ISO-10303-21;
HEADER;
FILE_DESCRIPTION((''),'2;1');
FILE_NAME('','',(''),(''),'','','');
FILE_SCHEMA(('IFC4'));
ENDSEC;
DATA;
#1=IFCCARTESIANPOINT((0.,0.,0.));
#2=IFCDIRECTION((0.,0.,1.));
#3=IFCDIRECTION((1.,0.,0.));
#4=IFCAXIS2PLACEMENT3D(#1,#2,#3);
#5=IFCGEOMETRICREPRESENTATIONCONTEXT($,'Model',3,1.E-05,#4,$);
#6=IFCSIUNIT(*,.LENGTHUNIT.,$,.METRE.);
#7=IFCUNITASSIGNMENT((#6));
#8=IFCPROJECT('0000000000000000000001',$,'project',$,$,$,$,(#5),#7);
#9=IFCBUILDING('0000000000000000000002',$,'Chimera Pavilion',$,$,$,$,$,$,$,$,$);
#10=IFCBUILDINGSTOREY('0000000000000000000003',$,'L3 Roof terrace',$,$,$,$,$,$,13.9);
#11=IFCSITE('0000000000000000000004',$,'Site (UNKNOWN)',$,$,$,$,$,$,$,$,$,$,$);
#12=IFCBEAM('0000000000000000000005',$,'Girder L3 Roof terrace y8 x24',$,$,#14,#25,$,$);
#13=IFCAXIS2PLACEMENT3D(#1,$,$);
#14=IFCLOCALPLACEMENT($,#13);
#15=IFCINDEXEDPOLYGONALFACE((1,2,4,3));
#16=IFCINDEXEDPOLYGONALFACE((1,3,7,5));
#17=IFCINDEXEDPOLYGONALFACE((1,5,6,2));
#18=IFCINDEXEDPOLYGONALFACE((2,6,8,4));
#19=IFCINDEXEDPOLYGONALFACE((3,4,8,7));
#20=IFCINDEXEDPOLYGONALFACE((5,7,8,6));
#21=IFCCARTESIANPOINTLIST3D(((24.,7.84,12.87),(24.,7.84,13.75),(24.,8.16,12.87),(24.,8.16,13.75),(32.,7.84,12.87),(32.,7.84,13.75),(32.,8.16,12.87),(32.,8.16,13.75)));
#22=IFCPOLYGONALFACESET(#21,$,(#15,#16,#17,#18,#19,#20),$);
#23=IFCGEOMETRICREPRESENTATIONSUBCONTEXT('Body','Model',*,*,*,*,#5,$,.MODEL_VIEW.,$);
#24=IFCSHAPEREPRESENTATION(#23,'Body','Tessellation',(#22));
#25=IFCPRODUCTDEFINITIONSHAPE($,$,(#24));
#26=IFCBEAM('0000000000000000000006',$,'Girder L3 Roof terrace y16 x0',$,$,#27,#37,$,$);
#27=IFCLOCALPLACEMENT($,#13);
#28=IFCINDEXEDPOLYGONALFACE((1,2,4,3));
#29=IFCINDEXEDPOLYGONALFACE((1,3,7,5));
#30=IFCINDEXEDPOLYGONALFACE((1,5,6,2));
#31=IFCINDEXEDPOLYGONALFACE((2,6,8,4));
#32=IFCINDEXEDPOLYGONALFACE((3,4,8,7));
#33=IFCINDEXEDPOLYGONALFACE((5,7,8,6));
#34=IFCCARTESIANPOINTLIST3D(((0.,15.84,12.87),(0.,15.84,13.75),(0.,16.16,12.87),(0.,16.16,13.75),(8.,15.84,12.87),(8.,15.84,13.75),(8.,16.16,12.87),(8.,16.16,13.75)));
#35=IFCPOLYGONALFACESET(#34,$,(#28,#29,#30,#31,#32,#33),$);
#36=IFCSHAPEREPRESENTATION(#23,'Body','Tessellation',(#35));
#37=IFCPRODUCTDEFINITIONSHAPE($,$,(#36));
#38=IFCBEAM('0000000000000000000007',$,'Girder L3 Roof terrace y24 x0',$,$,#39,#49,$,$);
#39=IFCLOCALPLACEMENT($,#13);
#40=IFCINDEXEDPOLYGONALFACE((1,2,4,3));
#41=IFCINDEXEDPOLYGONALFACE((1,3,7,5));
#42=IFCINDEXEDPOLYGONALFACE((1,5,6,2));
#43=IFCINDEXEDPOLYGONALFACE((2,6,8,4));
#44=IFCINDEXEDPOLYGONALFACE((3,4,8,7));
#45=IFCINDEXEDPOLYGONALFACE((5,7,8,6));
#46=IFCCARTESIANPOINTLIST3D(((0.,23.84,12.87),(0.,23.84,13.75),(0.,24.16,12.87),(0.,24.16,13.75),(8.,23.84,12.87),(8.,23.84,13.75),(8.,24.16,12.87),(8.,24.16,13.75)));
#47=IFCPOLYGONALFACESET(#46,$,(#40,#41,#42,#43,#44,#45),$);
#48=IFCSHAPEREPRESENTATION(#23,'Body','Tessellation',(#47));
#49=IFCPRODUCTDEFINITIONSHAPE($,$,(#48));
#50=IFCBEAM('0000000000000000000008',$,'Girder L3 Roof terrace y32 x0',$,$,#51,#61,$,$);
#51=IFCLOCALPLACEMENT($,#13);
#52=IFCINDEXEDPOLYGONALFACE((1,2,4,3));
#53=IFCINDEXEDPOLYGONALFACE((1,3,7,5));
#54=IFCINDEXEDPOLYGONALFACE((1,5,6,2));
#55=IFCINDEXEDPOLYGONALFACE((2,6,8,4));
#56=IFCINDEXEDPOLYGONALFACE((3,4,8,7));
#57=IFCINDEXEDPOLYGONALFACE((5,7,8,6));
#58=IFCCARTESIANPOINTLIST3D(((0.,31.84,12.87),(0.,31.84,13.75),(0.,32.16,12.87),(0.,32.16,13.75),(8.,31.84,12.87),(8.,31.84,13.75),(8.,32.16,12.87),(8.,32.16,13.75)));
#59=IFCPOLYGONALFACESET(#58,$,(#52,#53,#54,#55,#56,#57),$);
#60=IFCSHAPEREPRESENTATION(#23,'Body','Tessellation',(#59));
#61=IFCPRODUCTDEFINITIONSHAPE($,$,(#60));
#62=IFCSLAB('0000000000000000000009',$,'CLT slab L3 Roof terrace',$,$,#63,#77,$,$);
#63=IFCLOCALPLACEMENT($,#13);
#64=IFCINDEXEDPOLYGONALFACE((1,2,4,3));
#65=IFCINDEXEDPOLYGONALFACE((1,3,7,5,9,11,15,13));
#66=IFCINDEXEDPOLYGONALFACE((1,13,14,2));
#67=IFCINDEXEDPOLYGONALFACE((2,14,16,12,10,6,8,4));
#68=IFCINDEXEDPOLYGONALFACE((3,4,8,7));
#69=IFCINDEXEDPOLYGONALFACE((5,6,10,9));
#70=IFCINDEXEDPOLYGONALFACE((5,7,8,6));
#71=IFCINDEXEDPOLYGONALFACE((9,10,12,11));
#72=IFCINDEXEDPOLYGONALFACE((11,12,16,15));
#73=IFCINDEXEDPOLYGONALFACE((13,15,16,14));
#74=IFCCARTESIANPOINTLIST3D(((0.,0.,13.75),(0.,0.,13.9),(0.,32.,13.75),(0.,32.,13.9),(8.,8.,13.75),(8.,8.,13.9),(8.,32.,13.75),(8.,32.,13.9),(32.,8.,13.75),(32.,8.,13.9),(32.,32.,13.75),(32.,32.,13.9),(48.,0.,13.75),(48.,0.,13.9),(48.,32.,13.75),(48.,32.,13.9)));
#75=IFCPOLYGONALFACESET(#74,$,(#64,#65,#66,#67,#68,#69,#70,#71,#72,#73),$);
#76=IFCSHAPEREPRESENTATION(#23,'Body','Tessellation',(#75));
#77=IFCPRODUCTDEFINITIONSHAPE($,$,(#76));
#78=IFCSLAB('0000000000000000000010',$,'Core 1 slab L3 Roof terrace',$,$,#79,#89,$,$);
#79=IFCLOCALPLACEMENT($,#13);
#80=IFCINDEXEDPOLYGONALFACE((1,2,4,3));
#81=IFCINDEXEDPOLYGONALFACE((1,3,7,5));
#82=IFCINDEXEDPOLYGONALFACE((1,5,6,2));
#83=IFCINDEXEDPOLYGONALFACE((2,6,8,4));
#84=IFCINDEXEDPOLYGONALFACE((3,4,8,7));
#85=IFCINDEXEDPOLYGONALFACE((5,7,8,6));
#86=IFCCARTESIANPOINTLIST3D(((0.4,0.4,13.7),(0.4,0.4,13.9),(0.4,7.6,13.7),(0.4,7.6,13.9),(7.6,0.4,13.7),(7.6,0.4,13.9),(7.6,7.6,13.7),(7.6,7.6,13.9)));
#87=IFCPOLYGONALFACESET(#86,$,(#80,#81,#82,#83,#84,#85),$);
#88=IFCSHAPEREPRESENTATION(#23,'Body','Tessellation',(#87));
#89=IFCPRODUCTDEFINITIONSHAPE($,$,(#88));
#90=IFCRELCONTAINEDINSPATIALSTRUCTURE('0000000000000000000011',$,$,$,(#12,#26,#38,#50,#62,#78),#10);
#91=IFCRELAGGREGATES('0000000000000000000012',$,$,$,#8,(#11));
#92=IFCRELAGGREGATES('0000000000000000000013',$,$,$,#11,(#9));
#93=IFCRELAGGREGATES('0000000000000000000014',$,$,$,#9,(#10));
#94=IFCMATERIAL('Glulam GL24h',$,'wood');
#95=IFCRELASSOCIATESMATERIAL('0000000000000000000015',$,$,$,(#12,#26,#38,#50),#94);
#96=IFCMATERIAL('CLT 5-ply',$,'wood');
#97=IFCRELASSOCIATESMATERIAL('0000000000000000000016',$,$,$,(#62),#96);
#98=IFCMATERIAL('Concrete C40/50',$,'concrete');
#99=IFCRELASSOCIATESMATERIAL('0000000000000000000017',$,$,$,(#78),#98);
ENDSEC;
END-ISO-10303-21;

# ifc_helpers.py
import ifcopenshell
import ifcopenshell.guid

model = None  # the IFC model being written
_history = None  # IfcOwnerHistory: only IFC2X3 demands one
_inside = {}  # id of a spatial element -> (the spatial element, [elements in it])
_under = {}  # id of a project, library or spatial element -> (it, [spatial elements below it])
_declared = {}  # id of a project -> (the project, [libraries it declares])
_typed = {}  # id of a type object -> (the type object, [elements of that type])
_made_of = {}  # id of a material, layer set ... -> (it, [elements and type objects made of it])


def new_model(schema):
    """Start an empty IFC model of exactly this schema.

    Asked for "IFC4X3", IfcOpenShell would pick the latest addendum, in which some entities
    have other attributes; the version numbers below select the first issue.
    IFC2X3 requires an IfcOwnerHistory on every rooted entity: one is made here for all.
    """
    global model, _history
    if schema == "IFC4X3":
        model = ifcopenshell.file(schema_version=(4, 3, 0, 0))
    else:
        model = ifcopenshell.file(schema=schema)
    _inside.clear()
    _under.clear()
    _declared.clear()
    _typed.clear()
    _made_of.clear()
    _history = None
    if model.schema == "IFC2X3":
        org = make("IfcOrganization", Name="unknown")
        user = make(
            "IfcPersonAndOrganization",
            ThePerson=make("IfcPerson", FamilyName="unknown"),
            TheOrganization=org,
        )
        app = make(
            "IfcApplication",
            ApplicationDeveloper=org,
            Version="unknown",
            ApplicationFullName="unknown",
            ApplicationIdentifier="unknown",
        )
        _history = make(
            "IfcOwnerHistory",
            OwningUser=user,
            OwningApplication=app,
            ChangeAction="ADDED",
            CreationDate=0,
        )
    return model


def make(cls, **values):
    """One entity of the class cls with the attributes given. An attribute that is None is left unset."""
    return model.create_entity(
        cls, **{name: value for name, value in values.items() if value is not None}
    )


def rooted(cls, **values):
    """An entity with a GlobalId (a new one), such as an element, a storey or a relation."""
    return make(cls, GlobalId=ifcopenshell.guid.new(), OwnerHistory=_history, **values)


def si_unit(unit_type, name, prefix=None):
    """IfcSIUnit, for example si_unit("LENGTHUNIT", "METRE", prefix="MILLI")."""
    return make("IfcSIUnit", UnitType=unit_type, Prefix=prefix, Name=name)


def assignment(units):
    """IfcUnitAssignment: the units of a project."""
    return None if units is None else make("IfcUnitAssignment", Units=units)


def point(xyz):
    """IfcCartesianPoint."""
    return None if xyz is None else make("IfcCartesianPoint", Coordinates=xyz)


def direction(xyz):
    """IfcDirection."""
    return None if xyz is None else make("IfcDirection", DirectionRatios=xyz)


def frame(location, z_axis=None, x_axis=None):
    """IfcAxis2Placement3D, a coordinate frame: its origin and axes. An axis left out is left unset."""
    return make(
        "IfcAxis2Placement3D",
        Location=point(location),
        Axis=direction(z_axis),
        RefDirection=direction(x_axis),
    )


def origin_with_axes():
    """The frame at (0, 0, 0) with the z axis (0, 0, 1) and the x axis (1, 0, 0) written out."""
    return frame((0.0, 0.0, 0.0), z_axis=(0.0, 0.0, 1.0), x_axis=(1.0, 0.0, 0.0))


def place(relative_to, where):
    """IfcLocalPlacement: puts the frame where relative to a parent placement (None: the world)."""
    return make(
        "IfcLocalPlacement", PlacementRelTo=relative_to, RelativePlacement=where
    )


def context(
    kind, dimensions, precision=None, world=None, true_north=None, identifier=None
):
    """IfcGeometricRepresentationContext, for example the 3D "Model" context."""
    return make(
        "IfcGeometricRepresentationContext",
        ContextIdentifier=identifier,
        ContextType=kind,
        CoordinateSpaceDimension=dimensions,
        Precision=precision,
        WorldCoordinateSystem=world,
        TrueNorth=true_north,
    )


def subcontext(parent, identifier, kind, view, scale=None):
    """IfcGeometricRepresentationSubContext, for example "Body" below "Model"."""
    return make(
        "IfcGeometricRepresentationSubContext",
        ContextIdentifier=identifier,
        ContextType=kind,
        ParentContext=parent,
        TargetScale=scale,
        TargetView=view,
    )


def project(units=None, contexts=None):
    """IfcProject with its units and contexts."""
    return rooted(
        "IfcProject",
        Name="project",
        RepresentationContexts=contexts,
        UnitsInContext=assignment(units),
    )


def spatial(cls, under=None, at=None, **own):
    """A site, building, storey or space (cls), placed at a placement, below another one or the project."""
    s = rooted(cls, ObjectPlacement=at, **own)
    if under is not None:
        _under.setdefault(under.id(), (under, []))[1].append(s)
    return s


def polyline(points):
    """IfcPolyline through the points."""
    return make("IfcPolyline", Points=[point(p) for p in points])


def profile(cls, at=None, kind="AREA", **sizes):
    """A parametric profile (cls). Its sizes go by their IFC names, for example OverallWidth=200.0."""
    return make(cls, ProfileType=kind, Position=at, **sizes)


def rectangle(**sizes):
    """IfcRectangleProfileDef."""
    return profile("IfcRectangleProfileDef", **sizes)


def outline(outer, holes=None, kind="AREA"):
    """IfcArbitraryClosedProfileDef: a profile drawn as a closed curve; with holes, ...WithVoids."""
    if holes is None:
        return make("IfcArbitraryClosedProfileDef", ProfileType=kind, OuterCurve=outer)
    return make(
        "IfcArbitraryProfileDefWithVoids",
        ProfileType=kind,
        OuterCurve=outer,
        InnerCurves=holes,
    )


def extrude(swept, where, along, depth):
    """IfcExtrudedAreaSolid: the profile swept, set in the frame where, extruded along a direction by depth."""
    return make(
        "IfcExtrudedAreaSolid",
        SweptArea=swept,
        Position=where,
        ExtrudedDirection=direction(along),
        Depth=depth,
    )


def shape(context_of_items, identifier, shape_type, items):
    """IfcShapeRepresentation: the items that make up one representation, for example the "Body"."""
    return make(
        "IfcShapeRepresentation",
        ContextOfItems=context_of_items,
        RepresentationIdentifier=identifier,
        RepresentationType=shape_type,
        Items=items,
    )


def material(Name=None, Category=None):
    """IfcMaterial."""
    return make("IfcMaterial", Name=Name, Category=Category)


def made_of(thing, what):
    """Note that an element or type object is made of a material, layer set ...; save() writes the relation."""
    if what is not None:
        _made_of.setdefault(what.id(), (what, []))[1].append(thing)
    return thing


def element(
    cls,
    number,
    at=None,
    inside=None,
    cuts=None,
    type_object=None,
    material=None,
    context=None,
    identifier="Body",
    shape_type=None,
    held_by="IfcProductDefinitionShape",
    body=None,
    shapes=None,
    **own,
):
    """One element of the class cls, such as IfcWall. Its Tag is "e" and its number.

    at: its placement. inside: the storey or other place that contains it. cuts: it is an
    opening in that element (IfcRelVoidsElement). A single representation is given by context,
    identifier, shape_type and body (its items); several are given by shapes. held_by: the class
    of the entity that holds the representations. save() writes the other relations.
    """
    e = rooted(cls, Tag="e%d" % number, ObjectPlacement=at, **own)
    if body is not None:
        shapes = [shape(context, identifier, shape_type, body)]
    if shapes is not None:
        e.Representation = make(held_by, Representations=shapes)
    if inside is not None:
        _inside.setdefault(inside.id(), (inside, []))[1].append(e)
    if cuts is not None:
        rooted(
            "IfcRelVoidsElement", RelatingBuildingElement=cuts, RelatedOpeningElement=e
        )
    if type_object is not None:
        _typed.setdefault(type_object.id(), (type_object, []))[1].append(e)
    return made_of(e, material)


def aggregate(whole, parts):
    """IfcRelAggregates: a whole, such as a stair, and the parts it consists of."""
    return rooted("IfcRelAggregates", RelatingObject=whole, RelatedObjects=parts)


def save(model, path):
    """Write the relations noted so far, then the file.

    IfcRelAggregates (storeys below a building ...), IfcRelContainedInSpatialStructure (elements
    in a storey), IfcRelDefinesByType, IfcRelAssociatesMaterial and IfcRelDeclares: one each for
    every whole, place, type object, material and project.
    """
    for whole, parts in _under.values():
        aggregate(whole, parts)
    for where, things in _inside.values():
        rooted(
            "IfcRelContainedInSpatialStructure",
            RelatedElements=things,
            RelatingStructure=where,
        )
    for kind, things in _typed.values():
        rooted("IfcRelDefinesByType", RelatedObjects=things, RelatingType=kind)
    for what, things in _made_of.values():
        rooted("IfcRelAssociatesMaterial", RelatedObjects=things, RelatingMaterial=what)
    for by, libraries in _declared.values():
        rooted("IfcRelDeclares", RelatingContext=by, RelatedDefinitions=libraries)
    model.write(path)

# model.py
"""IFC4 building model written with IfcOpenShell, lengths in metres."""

from ifc_helpers import new_model, si_unit, frame, origin_with_axes, place, context, subcontext, project, spatial, polyline, rectangle, outline, extrude, material, element, save


model = new_model("IFC4")

# Units and contexts
model_context = context("Model", 3, precision=1e-05, world=origin_with_axes())
body_context = subcontext(model_context, "Body", "Model", "MODEL_VIEW")
ifc_project = project(units=[si_unit("LENGTHUNIT", "METRE")], contexts=[model_context])

# Site, building, storey
site = spatial("IfcSite", under=ifc_project, Name="Site (UNKNOWN)")
building = spatial("IfcBuilding", under=site, Name="Chimera Pavilion")
storey = spatial("IfcBuildingStorey", under=building, Name="L3 Roof terrace", Elevation=13.9)

# Beams
ifc_material_1 = material(Name="Glulam GL24h", Category="wood")
for number, where, z_axis, x_axis, name in (
    (1, (24.0, 8.0, 13.31), (1.0, 0.0, 0.0), (0.0, -1.0, 0.0), "Girder L3 Roof terrace y8 x24"),
    (2, (0.0, 16.0, 13.31), (1.0, 0.0, 0.0), (0.0, -1.0, 0.0), "Girder L3 Roof terrace y16 x0"),
    (3, (0.0, 24.0, 13.31), (1.0, 0.0, 0.0), (0.0, -1.0, 0.0), "Girder L3 Roof terrace y24 x0"),
    (4, (0.0, 32.0, 13.31), (1.0, 0.0, 0.0), (0.0, -1.0, 0.0), "Girder L3 Roof terrace y32 x0"),
):
    element("IfcBeam", number, at=place(None, frame(where, z_axis=z_axis, x_axis=x_axis)), inside=storey, material=ifc_material_1, Name=name, context=body_context, shape_type="SweptSolid", body=[
        extrude(rectangle(XDim=0.32, YDim=0.88), origin_with_axes(), (0.0, 0.0, 1.0), 8.0),
    ])

# Slabs
ifc_material_2 = material(Name="CLT 5-ply", Category="wood")
slab_1_placement = place(None, frame((0.0, 0.0, 13.75), z_axis=(0.0, 0.0, 1.0), x_axis=(1.0, 0.0, 0.0)))
element("IfcSlab", 5, at=slab_1_placement, inside=storey, material=ifc_material_2, Name="CLT slab L3 Roof terrace", context=body_context, shape_type="SweptSolid", body=[
    extrude(outline(polyline([(0.0, 0.0), (48.0, 0.0), (48.0, 32.0), (32.0, 32.0), (32.0, 8.0), (8.0, 8.0), (8.0, 32.0), (0.0, 32.0), (0.0, 0.0)])), origin_with_axes(), (0.0, 0.0, 1.0), 0.15),
])
ifc_material_3 = material(Name="Concrete C40/50", Category="concrete")
slab_2_placement = place(None, frame((4.0, 4.0, 13.7), z_axis=(0.0, 0.0, 1.0), x_axis=(1.0, 0.0, 0.0)))
element("IfcSlab", 6, at=slab_2_placement, inside=storey, material=ifc_material_3, Name="Core 1 slab L3 Roof terrace", context=body_context, shape_type="SweptSolid", body=[
    extrude(rectangle(XDim=7.2, YDim=7.2), origin_with_axes(), (0.0, 0.0, 1.0), 0.2),
])

save(model, "model.ifc")
